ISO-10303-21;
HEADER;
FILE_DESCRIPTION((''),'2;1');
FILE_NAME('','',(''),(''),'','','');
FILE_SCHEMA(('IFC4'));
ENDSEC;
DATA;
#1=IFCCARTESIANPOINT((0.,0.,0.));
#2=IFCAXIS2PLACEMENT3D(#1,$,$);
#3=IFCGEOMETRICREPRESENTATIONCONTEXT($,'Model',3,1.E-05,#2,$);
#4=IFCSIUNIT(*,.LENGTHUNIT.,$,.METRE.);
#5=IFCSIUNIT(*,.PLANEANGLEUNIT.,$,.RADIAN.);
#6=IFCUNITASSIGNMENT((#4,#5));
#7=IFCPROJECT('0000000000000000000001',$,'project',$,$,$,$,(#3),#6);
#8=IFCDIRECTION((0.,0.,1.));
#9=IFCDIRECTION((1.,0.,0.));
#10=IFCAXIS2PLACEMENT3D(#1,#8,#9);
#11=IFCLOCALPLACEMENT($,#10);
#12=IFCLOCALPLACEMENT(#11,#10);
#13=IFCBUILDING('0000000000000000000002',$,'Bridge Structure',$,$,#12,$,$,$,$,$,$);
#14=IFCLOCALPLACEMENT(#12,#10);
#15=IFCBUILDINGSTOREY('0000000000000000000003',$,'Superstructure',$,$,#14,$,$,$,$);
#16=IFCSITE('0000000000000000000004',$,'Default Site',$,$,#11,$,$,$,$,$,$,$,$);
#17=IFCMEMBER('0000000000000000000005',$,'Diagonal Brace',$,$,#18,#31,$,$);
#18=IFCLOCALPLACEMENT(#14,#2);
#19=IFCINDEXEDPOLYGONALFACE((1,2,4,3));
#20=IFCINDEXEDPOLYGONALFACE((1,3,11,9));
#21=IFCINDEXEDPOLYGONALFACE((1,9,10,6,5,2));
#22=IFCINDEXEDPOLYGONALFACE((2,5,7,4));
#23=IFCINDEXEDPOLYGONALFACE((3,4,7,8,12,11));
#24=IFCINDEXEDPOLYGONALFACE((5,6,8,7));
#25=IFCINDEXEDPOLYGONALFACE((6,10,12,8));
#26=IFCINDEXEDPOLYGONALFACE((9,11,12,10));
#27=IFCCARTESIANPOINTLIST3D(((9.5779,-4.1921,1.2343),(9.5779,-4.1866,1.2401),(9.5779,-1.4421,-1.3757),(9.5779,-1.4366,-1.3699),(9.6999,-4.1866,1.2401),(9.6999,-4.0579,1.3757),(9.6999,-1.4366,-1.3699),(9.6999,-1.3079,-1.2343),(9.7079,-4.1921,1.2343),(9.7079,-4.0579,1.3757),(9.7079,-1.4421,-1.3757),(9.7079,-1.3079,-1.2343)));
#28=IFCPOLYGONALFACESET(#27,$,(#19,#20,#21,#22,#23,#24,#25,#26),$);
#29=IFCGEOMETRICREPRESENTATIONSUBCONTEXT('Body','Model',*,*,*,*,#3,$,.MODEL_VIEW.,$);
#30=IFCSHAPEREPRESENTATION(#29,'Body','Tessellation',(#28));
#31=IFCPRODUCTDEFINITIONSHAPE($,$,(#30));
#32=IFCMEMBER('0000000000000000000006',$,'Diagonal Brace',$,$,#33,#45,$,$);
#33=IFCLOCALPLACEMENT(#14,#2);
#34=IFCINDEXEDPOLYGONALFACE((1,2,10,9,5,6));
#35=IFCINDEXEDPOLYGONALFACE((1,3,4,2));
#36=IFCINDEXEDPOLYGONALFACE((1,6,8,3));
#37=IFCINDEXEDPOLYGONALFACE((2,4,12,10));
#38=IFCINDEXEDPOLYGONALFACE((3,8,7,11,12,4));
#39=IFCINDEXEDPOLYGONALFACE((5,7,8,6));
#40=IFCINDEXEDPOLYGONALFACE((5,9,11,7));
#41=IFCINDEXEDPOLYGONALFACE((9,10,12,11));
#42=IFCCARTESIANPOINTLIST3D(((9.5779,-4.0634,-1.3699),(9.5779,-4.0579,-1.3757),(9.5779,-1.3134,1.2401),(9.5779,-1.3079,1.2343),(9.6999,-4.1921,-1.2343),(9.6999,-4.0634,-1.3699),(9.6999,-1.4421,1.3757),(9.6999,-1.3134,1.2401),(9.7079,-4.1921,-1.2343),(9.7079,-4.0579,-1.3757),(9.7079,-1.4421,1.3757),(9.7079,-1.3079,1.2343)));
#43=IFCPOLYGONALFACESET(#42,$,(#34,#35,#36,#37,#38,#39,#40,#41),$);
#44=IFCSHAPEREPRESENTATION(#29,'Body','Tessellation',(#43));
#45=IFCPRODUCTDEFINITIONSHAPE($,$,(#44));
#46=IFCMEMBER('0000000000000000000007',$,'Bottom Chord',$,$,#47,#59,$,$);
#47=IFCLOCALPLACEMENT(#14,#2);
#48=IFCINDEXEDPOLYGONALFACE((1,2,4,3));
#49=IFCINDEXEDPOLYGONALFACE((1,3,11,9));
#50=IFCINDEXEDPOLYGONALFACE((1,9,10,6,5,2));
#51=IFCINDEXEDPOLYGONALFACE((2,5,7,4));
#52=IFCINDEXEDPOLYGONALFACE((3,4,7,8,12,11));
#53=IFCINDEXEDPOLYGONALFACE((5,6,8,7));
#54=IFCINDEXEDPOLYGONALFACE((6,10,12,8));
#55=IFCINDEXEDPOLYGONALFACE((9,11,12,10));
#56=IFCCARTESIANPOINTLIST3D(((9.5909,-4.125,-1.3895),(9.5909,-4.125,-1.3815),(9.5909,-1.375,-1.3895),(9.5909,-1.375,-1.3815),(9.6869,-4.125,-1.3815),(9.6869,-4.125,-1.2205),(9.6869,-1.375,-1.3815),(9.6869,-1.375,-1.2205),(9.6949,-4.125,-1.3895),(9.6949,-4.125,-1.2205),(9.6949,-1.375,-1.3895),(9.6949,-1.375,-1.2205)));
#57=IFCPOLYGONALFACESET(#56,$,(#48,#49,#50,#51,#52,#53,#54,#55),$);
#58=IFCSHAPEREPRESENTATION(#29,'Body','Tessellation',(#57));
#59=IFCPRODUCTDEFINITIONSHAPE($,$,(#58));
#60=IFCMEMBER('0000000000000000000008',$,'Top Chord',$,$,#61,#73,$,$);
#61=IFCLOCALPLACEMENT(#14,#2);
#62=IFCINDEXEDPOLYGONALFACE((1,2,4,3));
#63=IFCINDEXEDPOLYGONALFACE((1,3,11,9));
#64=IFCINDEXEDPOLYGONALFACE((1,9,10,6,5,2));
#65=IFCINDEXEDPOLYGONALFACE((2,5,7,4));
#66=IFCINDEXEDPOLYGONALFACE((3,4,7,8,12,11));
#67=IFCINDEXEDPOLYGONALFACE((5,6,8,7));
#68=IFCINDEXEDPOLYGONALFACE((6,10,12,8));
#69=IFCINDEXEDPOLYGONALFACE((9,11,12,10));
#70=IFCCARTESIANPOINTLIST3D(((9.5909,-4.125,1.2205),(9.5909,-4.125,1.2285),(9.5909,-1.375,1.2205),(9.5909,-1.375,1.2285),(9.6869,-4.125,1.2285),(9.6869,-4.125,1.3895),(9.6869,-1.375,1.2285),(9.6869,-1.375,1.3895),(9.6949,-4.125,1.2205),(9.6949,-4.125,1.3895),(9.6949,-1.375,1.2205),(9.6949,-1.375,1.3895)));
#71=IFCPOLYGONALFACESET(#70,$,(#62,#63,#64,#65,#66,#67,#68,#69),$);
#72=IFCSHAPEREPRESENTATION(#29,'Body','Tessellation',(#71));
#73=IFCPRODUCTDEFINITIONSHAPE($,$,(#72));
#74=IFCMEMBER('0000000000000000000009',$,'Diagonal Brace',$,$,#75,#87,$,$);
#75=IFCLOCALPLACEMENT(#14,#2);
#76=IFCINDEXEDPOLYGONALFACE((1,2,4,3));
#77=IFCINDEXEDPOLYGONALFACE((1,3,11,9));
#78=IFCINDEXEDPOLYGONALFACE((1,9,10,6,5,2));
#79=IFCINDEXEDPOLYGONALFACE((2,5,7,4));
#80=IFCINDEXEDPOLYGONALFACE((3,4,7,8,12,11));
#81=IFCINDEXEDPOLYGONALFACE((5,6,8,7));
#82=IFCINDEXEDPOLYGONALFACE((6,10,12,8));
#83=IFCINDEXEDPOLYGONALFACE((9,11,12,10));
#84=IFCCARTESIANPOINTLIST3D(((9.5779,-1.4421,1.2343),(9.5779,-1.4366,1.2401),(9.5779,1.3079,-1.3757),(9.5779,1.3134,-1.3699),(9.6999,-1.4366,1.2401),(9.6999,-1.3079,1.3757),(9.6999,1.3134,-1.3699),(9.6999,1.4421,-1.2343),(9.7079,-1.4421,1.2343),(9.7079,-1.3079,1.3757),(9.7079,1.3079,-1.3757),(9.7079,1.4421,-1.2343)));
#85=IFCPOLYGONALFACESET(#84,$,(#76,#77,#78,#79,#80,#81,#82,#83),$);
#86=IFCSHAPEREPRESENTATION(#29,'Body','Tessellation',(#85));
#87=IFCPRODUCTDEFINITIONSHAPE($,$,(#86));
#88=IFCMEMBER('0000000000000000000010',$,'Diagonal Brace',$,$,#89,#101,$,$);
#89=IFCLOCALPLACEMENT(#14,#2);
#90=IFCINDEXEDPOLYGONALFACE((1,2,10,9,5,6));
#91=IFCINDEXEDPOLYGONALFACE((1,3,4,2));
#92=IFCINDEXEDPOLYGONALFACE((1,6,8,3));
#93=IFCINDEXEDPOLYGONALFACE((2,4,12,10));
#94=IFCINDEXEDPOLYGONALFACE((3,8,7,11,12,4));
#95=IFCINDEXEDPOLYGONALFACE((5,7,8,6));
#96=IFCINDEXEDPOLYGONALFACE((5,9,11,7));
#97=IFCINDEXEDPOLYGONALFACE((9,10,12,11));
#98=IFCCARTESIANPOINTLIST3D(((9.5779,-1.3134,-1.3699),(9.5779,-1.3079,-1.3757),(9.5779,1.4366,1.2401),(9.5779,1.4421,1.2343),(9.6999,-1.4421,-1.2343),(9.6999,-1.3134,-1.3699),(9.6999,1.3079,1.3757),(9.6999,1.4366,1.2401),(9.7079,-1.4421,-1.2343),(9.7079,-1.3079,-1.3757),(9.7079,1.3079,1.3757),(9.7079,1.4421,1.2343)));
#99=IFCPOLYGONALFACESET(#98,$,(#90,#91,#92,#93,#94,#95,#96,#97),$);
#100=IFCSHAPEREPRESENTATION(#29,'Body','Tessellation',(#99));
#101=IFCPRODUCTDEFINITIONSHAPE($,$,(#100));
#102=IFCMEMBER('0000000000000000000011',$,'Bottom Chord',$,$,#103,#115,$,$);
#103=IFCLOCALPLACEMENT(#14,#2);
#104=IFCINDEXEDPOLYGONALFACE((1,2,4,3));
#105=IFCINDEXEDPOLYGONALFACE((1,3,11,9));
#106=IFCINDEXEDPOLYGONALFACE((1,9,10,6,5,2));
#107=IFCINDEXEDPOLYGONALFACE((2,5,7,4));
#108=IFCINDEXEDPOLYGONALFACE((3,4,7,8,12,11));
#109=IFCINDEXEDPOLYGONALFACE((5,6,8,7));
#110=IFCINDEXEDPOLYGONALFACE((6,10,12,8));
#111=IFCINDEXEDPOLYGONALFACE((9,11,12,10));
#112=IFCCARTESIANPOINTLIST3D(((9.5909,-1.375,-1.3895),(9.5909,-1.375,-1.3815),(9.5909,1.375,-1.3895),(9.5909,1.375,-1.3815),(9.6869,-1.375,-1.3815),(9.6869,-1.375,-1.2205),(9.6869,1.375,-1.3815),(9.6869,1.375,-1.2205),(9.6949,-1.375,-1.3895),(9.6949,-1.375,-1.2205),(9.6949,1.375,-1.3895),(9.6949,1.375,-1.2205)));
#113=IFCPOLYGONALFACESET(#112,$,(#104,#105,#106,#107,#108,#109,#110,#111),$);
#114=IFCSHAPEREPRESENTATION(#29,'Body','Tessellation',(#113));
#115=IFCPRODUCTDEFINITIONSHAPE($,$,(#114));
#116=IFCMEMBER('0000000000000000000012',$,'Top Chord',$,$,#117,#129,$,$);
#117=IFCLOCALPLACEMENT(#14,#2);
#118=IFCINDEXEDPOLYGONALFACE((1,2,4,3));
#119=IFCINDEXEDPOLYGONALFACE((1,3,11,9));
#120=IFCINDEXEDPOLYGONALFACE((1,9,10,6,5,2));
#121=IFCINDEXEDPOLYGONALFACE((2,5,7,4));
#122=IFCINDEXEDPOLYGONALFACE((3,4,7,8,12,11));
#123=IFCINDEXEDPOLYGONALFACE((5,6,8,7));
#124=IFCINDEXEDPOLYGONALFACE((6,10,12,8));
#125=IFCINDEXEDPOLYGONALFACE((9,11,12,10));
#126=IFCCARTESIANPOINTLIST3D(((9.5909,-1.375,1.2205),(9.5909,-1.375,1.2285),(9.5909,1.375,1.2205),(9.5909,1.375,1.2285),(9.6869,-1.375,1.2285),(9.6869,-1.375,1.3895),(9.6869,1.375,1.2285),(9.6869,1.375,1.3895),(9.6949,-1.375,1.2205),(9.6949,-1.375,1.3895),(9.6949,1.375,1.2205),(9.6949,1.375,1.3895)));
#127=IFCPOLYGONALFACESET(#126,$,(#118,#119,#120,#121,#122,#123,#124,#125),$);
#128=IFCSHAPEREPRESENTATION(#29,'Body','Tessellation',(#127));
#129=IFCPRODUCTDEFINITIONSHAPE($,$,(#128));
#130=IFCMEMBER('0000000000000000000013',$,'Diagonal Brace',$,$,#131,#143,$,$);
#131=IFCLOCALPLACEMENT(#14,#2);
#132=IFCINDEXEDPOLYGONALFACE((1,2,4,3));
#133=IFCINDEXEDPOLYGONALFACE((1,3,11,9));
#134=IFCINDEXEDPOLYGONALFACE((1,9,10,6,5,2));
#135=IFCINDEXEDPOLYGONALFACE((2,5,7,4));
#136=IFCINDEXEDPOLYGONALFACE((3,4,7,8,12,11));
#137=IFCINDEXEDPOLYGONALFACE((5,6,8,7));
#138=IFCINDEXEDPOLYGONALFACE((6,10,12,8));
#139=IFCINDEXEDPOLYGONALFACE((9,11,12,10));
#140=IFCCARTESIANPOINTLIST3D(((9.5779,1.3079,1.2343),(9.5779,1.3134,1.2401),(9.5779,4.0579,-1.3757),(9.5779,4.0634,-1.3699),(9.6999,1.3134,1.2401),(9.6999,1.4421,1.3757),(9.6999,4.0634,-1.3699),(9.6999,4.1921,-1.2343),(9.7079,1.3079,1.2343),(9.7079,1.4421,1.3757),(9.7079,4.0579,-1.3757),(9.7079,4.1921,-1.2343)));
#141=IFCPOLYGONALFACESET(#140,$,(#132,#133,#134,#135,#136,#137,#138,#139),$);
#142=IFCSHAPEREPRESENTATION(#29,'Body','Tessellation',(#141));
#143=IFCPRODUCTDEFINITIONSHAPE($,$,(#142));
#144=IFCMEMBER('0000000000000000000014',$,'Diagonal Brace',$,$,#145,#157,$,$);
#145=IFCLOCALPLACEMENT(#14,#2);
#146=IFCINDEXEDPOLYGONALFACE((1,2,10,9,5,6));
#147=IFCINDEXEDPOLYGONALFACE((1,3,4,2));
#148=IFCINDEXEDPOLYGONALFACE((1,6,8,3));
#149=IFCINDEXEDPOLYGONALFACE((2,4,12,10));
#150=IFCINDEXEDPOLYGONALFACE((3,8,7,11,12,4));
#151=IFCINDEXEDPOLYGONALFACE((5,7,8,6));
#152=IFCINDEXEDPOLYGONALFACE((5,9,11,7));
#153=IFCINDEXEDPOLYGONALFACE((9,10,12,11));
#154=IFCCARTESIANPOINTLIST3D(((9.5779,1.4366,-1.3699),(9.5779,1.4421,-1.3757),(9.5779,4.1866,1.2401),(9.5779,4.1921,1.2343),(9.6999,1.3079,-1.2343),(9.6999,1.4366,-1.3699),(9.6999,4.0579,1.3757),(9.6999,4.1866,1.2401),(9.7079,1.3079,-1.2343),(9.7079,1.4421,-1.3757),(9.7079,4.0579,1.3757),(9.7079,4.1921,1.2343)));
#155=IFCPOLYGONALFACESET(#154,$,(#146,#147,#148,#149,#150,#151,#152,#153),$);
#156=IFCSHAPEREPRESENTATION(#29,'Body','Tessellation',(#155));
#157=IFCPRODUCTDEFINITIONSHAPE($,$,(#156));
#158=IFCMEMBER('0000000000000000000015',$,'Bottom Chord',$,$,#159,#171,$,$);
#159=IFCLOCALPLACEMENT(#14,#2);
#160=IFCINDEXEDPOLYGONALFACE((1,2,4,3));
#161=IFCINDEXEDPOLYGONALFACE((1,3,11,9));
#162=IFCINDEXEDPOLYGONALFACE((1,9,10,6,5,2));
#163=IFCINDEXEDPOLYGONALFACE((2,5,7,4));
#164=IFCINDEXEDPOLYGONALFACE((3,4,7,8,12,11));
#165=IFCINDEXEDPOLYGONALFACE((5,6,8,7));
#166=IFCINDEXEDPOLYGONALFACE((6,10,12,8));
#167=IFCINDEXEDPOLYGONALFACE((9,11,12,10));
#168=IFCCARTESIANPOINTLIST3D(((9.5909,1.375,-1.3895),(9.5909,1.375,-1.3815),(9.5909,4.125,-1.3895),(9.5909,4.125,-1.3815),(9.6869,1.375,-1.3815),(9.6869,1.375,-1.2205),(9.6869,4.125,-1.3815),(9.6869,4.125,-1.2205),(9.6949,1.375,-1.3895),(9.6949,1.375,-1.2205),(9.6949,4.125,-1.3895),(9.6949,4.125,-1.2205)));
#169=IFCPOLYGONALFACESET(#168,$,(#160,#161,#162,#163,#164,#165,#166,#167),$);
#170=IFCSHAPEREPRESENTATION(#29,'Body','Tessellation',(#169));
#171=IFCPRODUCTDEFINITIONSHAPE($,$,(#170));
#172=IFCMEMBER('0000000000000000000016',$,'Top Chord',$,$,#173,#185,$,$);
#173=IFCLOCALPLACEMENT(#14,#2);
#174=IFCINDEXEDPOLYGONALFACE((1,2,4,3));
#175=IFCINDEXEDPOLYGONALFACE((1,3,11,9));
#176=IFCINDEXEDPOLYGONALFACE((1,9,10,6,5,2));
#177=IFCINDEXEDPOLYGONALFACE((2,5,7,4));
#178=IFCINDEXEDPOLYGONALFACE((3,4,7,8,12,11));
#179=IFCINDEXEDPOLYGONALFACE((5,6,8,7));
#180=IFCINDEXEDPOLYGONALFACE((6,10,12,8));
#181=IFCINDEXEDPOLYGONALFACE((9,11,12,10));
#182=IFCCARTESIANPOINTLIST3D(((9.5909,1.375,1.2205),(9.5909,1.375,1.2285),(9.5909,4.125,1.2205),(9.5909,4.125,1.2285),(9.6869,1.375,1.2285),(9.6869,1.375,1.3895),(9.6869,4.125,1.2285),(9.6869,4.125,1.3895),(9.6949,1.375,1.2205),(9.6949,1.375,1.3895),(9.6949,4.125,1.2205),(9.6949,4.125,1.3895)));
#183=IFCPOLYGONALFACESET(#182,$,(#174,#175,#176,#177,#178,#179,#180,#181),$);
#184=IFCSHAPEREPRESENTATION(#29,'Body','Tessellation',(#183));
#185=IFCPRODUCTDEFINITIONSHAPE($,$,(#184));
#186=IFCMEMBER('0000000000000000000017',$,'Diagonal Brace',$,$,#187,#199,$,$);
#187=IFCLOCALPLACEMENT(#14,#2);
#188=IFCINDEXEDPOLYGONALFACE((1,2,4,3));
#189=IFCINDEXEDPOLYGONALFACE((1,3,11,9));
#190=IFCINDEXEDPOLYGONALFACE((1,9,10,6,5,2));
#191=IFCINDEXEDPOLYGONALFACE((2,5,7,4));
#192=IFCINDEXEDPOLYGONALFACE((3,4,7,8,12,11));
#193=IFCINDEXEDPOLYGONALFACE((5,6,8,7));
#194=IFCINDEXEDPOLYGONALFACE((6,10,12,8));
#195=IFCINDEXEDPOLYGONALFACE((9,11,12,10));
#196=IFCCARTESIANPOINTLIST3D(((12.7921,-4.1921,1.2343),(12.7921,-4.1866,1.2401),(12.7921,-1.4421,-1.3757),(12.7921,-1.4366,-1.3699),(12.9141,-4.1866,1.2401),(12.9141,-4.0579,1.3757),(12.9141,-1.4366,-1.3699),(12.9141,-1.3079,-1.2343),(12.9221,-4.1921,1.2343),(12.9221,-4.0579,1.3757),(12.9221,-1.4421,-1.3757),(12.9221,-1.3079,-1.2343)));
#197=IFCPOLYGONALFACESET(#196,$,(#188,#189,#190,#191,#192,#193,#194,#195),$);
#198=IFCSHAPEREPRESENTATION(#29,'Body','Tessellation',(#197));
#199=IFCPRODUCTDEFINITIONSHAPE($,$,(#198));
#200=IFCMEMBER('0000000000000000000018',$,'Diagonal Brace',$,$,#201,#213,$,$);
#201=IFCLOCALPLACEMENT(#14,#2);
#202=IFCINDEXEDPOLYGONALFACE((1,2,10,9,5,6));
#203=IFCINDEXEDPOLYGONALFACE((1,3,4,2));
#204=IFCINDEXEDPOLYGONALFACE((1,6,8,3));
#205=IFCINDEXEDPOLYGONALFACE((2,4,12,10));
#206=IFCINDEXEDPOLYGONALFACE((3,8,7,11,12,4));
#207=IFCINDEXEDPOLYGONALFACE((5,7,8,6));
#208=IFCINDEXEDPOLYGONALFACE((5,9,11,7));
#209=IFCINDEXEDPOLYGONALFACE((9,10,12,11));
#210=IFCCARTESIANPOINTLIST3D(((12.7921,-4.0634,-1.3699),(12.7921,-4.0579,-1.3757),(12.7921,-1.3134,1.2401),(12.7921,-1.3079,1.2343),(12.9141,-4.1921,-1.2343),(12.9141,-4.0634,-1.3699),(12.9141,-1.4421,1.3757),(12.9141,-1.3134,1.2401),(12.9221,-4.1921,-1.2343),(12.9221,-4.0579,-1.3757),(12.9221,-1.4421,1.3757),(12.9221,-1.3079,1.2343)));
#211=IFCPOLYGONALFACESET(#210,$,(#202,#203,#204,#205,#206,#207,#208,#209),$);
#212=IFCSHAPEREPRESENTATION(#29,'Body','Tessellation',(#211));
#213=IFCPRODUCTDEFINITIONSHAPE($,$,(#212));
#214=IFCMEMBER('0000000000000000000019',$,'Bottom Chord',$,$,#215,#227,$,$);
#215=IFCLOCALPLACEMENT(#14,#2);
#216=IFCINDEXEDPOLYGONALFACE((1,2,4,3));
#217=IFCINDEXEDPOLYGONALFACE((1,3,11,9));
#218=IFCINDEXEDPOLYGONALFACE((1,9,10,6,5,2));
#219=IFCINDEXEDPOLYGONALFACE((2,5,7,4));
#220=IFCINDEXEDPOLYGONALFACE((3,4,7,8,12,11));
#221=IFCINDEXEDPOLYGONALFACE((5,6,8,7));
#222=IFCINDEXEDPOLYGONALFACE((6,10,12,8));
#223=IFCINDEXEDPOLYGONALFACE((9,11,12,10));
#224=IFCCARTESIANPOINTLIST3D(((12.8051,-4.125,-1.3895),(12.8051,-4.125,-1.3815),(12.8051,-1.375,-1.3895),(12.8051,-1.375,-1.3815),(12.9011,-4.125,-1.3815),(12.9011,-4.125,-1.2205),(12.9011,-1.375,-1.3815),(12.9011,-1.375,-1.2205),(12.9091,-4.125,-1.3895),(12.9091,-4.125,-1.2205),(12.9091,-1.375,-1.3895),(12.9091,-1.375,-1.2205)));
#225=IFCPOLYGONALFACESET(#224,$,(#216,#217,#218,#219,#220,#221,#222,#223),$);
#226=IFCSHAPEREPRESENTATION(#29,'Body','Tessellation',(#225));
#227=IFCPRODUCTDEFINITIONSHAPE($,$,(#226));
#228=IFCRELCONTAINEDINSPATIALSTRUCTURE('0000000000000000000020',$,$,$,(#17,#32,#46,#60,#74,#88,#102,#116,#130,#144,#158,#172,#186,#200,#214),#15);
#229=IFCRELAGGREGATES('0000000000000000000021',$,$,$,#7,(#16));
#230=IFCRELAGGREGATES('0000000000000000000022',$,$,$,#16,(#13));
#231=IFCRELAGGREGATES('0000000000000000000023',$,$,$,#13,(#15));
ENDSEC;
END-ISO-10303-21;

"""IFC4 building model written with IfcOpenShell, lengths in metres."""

from ifc_helpers import new_model, si_unit, frame, origin, origin_with_axes, origin_2d_with_axis, place, context, subcontext, project, spatial, l_section, extrude, element, save


model = new_model("IFC4")

# Units and contexts
model_context = context("Model", 3, precision=1e-05, world=origin())
body_context = subcontext(model_context, "Body", "Model", "MODEL_VIEW")
ifc_project = project(units=[si_unit("LENGTHUNIT", "METRE"), si_unit("PLANEANGLEUNIT", "RADIAN")], contexts=[model_context])

# Site, building, storey
site_placement = place(None, origin_with_axes())
site = spatial("IfcSite", under=ifc_project, at=site_placement, Name="Default Site")
building_placement = place(site_placement, origin_with_axes())
building = spatial("IfcBuilding", under=site, at=building_placement, Name="Bridge Structure")
storey_placement = place(building_placement, origin_with_axes())
storey = spatial("IfcBuildingStorey", under=building, at=storey_placement, Name="Superstructure")

# Members
for number, where, z_axis, x_axis, name in (
    (1, (9.6429, -4.125, 1.305), (0.0, 0.725329, -0.688403), (-1.0, 0.0, 0.0), "Diagonal Brace"),
    (2, (9.6429, -4.125, -1.305), (0.0, 0.725329, 0.688403), (-1.0, 0.0, 0.0), "Diagonal Brace"),
):
    element("IfcMember", number, at=place(storey_placement, frame(where, z_axis=z_axis, x_axis=x_axis)), inside=storey, Name=name, context=body_context, shape_type="SweptSolid", body=[
        extrude(l_section(Depth=0.195, Width=0.13, Thickness=0.008, at=origin_2d_with_axis()), origin_with_axes(), (0.0, 0.0, 1.0), 3.7914),
    ])
for number, where, z_axis, x_axis, name in (
    (3, (9.6429, -4.125, -1.305), (0.0, 1.0, 0.0), (-1.0, 0.0, 0.0), "Bottom Chord"),
    (4, (9.6429, -4.125, 1.305), (0.0, 1.0, 0.0), (-1.0, 0.0, 0.0), "Top Chord"),
):
    element("IfcMember", number, at=place(storey_placement, frame(where, z_axis=z_axis, x_axis=x_axis)), inside=storey, Name=name, context=body_context, shape_type="SweptSolid", body=[
        extrude(l_section(Depth=0.169, Width=0.104, Thickness=0.008, at=origin_2d_with_axis()), origin_with_axes(), (0.0, 0.0, 1.0), 2.75),
    ])
for number, where, z_axis, x_axis, name in (
    (5, (9.6429, -1.375, 1.305), (0.0, 0.725329, -0.688403), (-1.0, 0.0, 0.0), "Diagonal Brace"),
    (6, (9.6429, -1.375, -1.305), (0.0, 0.725329, 0.688403), (-1.0, 0.0, 0.0), "Diagonal Brace"),
):
    element("IfcMember", number, at=place(storey_placement, frame(where, z_axis=z_axis, x_axis=x_axis)), inside=storey, Name=name, context=body_context, shape_type="SweptSolid", body=[
        extrude(l_section(Depth=0.195, Width=0.13, Thickness=0.008, at=origin_2d_with_axis()), origin_with_axes(), (0.0, 0.0, 1.0), 3.7914),
    ])
for number, where, z_axis, x_axis, name in (
    (7, (9.6429, -1.375, -1.305), (0.0, 1.0, 0.0), (-1.0, 0.0, 0.0), "Bottom Chord"),
    (8, (9.6429, -1.375, 1.305), (0.0, 1.0, 0.0), (-1.0, 0.0, 0.0), "Top Chord"),
):
    element("IfcMember", number, at=place(storey_placement, frame(where, z_axis=z_axis, x_axis=x_axis)), inside=storey, Name=name, context=body_context, shape_type="SweptSolid", body=[
        extrude(l_section(Depth=0.169, Width=0.104, Thickness=0.008, at=origin_2d_with_axis()), origin_with_axes(), (0.0, 0.0, 1.0), 2.75),
    ])
for number, where, z_axis, x_axis, name in (
    (9, (9.6429, 1.375, 1.305), (0.0, 0.725329, -0.688403), (-1.0, 0.0, 0.0), "Diagonal Brace"),
    (10, (9.6429, 1.375, -1.305), (0.0, 0.725329, 0.688403), (-1.0, 0.0, 0.0), "Diagonal Brace"),
):
    element("IfcMember", number, at=place(storey_placement, frame(where, z_axis=z_axis, x_axis=x_axis)), inside=storey, Name=name, context=body_context, shape_type="SweptSolid", body=[
        extrude(l_section(Depth=0.195, Width=0.13, Thickness=0.008, at=origin_2d_with_axis()), origin_with_axes(), (0.0, 0.0, 1.0), 3.7914),
    ])
for number, where, z_axis, x_axis, name in (
    (11, (9.6429, 1.375, -1.305), (0.0, 1.0, 0.0), (-1.0, 0.0, 0.0), "Bottom Chord"),
    (12, (9.6429, 1.375, 1.305), (0.0, 1.0, 0.0), (-1.0, 0.0, 0.0), "Top Chord"),
):
    element("IfcMember", number, at=place(storey_placement, frame(where, z_axis=z_axis, x_axis=x_axis)), inside=storey, Name=name, context=body_context, shape_type="SweptSolid", body=[
        extrude(l_section(Depth=0.169, Width=0.104, Thickness=0.008, at=origin_2d_with_axis()), origin_with_axes(), (0.0, 0.0, 1.0), 2.75),
    ])
for number, where, z_axis, x_axis, name in (
    (13, (12.8571, -4.125, 1.305), (0.0, 0.725329, -0.688403), (-1.0, 0.0, 0.0), "Diagonal Brace"),
    (14, (12.8571, -4.125, -1.305), (0.0, 0.725329, 0.688403), (-1.0, 0.0, 0.0), "Diagonal Brace"),
):
    element("IfcMember", number, at=place(storey_placement, frame(where, z_axis=z_axis, x_axis=x_axis)), inside=storey, Name=name, context=body_context, shape_type="SweptSolid", body=[
        extrude(l_section(Depth=0.195, Width=0.13, Thickness=0.008, at=origin_2d_with_axis()), origin_with_axes(), (0.0, 0.0, 1.0), 3.7914),
    ])
for number, where, z_axis, x_axis, name in (
    (15, (12.8571, -4.125, -1.305), (0.0, 1.0, 0.0), (-1.0, 0.0, 0.0), "Bottom Chord"),
):
    element("IfcMember", number, at=place(storey_placement, frame(where, z_axis=z_axis, x_axis=x_axis)), inside=storey, Name=name, context=body_context, shape_type="SweptSolid", body=[
        extrude(l_section(Depth=0.169, Width=0.104, Thickness=0.008, at=origin_2d_with_axis()), origin_with_axes(), (0.0, 0.0, 1.0), 2.75),
    ])

save(model, "model.ifc")
